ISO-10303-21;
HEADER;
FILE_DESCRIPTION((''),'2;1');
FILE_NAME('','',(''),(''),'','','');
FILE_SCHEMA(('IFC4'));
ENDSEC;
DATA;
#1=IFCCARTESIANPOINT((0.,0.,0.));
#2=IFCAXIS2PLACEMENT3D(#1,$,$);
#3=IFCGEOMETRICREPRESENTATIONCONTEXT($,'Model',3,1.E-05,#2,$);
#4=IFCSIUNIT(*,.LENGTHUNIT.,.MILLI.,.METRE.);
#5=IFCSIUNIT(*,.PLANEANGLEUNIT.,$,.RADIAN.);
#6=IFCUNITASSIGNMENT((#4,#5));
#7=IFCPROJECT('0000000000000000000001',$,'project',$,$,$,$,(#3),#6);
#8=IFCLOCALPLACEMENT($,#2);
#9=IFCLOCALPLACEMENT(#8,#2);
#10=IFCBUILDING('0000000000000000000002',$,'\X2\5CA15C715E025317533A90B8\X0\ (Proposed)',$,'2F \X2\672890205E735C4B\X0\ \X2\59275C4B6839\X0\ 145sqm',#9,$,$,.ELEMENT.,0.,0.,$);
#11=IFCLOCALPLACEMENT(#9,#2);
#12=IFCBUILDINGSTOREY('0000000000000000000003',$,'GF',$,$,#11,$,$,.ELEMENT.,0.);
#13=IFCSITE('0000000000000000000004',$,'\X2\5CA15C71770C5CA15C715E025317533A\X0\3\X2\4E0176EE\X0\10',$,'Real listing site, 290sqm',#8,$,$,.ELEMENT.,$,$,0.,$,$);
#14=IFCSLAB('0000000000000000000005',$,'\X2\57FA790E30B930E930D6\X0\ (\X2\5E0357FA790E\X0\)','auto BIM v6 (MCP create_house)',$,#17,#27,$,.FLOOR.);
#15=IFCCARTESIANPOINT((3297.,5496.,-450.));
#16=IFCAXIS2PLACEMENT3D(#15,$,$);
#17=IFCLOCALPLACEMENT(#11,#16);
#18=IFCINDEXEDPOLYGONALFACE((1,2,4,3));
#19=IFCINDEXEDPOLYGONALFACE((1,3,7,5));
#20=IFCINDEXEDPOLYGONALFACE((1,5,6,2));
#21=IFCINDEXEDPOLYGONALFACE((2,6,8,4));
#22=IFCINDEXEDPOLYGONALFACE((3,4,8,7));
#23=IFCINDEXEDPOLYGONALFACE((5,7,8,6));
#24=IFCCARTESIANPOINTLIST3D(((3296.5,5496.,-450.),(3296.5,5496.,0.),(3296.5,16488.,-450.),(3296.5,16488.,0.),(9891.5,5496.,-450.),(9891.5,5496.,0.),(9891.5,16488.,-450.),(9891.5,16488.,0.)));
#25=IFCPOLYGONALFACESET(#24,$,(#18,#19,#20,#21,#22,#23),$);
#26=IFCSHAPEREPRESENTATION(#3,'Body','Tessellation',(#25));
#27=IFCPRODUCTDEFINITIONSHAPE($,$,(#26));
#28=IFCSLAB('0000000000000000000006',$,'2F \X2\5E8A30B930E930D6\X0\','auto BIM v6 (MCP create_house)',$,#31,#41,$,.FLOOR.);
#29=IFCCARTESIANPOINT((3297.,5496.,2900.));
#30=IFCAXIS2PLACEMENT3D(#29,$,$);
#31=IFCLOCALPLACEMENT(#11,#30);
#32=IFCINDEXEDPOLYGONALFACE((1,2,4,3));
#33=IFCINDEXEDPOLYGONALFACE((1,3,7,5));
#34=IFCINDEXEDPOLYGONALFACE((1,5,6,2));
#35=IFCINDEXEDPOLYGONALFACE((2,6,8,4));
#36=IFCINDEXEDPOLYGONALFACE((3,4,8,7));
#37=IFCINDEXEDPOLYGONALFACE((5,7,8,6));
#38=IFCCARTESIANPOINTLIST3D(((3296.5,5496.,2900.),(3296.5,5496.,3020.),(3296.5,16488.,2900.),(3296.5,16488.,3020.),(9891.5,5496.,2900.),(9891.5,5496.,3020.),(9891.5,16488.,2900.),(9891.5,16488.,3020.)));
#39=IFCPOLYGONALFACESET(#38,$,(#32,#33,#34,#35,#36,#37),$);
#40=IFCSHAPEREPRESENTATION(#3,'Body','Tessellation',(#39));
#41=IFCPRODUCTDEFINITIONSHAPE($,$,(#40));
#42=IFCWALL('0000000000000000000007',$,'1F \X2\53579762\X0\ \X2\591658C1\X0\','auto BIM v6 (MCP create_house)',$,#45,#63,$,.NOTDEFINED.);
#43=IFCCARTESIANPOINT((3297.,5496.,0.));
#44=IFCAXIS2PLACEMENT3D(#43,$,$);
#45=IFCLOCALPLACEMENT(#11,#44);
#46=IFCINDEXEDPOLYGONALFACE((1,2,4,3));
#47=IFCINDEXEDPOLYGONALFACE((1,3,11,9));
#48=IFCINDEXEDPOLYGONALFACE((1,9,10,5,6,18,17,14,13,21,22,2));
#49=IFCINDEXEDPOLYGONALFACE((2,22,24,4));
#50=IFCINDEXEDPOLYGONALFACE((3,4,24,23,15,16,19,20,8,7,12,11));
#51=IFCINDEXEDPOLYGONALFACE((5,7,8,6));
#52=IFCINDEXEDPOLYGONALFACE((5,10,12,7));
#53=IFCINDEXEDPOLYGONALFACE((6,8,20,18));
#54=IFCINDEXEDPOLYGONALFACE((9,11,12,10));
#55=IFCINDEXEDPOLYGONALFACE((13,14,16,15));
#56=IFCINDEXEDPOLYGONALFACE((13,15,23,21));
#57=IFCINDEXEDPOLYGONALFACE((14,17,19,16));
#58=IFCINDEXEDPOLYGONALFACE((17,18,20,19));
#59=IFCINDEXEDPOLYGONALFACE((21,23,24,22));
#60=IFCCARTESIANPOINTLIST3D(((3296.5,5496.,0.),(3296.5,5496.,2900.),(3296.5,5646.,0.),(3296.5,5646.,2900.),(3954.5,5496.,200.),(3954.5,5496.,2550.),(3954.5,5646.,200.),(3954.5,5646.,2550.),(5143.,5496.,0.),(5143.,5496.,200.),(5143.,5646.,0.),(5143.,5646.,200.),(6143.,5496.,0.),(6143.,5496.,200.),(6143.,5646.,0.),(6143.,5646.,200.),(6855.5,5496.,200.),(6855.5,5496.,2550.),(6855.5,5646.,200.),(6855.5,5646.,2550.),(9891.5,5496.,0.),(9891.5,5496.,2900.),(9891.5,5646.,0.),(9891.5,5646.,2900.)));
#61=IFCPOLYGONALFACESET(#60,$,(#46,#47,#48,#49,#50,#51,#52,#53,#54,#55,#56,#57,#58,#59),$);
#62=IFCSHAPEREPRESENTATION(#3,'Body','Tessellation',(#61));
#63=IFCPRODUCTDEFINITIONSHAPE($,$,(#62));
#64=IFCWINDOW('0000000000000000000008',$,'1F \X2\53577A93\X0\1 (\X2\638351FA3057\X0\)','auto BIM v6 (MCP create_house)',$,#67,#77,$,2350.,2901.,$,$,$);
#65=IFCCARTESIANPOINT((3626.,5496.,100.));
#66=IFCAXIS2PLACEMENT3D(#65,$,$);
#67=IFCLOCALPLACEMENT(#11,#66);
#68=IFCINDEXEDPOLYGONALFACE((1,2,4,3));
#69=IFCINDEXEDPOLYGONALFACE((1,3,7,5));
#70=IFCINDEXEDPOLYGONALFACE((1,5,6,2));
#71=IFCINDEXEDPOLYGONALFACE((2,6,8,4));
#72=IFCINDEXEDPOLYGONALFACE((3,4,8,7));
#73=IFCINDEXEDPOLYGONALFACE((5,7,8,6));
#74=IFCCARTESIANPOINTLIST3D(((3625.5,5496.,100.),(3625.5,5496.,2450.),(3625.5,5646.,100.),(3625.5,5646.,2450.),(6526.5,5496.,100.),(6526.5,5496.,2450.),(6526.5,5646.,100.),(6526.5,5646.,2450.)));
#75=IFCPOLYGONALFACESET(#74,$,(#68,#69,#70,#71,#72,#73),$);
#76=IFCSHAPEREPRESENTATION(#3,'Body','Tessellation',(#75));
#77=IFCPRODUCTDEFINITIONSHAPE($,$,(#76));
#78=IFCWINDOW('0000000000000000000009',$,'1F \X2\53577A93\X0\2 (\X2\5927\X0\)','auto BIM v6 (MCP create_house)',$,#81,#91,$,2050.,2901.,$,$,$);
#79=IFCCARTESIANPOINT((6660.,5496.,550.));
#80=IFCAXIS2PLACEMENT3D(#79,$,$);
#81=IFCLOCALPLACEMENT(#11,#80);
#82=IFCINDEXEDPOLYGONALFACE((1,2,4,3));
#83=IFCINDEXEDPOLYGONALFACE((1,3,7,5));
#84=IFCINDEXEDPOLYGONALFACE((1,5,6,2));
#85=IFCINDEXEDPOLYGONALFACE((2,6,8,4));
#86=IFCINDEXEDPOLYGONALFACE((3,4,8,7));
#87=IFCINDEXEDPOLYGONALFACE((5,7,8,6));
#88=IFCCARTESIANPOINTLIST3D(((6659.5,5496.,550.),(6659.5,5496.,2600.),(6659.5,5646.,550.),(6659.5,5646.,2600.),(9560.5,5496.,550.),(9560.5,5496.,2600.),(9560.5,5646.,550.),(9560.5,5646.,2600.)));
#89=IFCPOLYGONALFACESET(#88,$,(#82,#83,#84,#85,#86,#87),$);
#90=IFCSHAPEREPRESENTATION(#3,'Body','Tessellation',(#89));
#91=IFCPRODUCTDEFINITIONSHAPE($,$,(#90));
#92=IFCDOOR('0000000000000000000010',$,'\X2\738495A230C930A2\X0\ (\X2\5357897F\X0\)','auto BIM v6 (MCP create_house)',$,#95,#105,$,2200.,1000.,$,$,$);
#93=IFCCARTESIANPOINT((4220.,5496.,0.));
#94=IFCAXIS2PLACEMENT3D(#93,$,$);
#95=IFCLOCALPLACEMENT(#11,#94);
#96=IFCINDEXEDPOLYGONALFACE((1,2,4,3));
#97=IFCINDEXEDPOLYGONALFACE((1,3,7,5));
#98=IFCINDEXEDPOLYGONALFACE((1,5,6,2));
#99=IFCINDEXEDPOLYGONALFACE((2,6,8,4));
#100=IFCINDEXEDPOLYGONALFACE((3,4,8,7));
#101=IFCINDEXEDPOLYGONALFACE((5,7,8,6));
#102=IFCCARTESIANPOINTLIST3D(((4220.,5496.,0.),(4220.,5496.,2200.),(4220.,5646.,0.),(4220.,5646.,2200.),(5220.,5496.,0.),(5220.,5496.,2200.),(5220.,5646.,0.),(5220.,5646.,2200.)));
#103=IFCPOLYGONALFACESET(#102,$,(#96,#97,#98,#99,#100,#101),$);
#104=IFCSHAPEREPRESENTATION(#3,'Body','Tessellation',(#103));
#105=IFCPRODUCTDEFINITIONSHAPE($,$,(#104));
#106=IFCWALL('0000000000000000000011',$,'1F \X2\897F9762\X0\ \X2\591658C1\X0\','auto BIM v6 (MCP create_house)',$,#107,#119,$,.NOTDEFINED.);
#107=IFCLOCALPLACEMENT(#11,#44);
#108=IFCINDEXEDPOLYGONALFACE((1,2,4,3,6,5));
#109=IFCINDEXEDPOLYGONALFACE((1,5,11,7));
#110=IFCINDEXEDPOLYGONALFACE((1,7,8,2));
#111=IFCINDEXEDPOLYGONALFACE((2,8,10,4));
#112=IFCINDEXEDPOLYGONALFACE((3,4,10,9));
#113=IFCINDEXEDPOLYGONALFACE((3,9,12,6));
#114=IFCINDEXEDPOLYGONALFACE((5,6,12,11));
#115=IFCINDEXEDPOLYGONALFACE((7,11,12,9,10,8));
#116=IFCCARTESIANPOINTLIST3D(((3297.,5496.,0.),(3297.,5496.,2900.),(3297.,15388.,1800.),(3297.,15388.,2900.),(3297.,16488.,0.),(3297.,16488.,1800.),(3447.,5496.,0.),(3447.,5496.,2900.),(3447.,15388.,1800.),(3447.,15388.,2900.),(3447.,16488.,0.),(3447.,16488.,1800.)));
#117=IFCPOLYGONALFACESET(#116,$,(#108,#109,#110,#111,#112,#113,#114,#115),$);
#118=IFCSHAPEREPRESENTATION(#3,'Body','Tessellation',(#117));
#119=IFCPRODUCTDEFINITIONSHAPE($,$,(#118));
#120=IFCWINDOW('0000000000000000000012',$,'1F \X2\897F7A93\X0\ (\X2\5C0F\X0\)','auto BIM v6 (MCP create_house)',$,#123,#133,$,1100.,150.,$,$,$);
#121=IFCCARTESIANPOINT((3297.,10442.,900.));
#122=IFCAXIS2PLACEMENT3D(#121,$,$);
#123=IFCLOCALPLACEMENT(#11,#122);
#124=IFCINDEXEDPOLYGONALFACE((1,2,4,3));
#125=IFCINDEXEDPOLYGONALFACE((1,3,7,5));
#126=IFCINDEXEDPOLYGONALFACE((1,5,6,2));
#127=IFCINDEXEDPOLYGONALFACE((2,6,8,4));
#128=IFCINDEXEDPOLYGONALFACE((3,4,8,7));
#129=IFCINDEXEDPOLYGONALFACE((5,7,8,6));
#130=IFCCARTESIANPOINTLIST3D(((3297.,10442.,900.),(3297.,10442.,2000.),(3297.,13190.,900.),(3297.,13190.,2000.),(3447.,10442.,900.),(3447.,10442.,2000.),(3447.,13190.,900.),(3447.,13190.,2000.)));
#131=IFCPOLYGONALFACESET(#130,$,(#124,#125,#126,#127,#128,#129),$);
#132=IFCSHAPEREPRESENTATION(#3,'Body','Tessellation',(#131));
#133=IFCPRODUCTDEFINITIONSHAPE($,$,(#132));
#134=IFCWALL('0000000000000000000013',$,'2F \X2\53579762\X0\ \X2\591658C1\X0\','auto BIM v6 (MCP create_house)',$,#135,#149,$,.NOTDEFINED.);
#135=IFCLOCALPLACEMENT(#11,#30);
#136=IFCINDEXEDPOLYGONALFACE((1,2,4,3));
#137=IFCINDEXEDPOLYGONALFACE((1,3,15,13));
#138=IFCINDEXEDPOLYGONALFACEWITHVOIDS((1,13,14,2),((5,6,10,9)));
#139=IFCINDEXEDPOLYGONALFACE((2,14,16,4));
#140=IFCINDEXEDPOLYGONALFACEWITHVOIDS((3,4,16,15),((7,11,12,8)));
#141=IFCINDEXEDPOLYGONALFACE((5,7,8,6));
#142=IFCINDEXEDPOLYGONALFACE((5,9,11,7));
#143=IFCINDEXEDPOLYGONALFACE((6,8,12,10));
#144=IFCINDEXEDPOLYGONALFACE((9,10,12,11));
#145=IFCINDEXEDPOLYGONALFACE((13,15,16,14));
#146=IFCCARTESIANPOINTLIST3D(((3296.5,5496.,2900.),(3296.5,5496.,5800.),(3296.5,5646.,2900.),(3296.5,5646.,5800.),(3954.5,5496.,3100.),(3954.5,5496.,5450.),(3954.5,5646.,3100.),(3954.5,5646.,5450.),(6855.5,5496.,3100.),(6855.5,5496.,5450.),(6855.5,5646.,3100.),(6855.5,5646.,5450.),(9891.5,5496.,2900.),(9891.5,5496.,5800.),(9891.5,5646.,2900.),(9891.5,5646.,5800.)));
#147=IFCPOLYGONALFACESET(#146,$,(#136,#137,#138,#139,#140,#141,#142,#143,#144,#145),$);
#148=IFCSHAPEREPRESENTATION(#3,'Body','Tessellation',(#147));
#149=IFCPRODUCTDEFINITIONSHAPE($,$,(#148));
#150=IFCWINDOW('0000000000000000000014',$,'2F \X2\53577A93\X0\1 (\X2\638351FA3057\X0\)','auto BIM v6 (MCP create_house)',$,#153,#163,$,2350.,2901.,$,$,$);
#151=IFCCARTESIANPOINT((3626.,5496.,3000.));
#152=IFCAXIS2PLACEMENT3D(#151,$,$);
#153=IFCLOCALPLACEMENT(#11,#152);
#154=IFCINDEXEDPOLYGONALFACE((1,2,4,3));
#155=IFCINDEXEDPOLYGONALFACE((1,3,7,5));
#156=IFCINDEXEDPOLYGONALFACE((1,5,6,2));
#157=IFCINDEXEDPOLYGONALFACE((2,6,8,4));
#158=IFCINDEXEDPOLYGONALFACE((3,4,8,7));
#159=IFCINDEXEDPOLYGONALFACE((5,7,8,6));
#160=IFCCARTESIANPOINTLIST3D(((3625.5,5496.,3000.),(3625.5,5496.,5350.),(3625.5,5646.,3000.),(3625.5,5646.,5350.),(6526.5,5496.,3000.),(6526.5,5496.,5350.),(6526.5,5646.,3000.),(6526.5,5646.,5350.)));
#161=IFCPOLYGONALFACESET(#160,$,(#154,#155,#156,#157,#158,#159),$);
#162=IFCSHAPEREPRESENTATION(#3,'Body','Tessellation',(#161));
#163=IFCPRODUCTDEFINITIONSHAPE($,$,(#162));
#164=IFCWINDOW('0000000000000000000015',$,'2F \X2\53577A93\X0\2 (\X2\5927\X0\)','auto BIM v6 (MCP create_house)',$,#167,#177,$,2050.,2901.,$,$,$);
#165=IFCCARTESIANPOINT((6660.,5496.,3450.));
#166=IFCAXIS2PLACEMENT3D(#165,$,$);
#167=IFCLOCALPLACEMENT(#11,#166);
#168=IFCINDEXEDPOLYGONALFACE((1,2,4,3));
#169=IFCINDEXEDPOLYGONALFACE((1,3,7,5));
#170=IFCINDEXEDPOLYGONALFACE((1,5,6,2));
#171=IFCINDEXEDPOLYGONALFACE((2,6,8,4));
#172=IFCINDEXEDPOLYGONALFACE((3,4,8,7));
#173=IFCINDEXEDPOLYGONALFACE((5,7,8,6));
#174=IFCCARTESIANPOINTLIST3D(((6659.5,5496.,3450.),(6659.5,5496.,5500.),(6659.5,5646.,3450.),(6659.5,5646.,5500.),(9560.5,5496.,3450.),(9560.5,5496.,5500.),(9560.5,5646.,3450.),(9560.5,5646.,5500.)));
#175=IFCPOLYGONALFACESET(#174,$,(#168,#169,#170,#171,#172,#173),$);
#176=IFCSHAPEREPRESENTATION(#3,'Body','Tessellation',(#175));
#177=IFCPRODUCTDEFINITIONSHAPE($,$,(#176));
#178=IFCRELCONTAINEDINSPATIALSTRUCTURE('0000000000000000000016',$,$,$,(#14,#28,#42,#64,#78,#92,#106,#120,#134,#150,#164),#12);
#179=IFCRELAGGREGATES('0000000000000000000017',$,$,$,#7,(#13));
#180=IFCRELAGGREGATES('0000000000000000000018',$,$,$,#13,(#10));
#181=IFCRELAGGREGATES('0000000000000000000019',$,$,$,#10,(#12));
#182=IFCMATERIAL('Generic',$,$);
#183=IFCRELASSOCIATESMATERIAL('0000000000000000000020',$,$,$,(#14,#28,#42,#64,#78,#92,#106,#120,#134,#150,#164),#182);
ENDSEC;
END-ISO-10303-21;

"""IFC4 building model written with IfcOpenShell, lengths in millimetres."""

from ifc_helpers import new_model, si_unit, frame, frame_2d, origin, place, context, project, spatial, rectangle, extrude, material, element, fill, save


model = new_model("IFC4")

# Units and contexts
model_context = context("Model", 3, precision=1e-05, world=origin())
ifc_project = project(units=[si_unit("LENGTHUNIT", "METRE", prefix="MILLI"), si_unit("PLANEANGLEUNIT", "RADIAN")], contexts=[model_context])

# Site, building, storey
site_placement = place(None, origin())
site = spatial("IfcSite", under=ifc_project, at=site_placement, Name="岡山県岡山市北区3丁目10", ObjectType="Real listing site, 290sqm", CompositionType="ELEMENT", RefElevation=0.0)
building_placement = place(site_placement, origin())
building = spatial("IfcBuilding", under=site, at=building_placement, Name="岡山市北区邸 (Proposed)", ObjectType="2F 木造平屋 大屋根 145sqm", CompositionType="ELEMENT", ElevationOfRefHeight=0.0, ElevationOfTerrain=0.0)
storey_placement = place(building_placement, origin())
storey = spatial("IfcBuildingStorey", under=building, at=storey_placement, Name="GF", CompositionType="ELEMENT", Elevation=0.0)

# Slabs
ifc_material = material(Name="Generic")
slab_1_placement = place(storey_placement, frame((3297.0, 5496.0, -450.0)))
element("IfcSlab", 1, at=slab_1_placement, inside=storey, material=ifc_material, Name="基礎スラブ (布基礎)", Description="auto BIM v6 (MCP create_house)", PredefinedType="FLOOR", context=model_context, shape_type="SweptSolid", body=[
    extrude(rectangle(XDim=6595.0, YDim=10992.0, at=frame_2d((3297.0, 5496.0))), frame((3297.0, 5496.0, -450.0)), (0.0, 0.0, 1.0), 450.0),
])
slab_2_placement = place(storey_placement, frame((3297.0, 5496.0, 2900.0)))
element("IfcSlab", 2, at=slab_2_placement, inside=storey, material=ifc_material, Name="2F 床スラブ", Description="auto BIM v6 (MCP create_house)", PredefinedType="FLOOR", context=model_context, shape_type="SweptSolid", body=[
    extrude(rectangle(XDim=6595.0, YDim=10992.0, at=frame_2d((3297.0, 5496.0))), frame((3297.0, 5496.0, 2900.0)), (0.0, 0.0, 1.0), 120.0),
])

# Wall, openings, windows, door
wall_1_placement = place(storey_placement, frame((3297.0, 5496.0, 0.0)))
wall_1 = element("IfcWall", 3, at=wall_1_placement, inside=storey, material=ifc_material, Name="1F 南面 外壁", Description="auto BIM v6 (MCP create_house)", PredefinedType="NOTDEFINED", context=model_context, shape_type="SweptSolid", body=[
    extrude(rectangle(XDim=6595.0, YDim=150.0, at=frame_2d((3297.0, 75.0))), frame((3297.0, 5496.0, 0.0)), (0.0, 0.0, 1.0), 2900.0),
])
opening_1_placement = place(storey_placement, frame((3626.0, 5496.0, 100.0)))
opening_1 = element("IfcOpeningElement", 4, at=opening_1_placement, cuts=wall_1, PredefinedType="NOTDEFINED", context=model_context, shape_type="SweptSolid", body=[
    extrude(rectangle(XDim=2901.0, YDim=150.0, at=frame_2d((1450.0, 75.0))), frame((3626.0, 5496.0, 100.0)), (0.0, 0.0, 1.0), 2350.0),
])
opening_2_placement = place(storey_placement, frame((6660.0, 5496.0, 550.0)))
opening_2 = element("IfcOpeningElement", 5, at=opening_2_placement, cuts=wall_1, PredefinedType="NOTDEFINED", context=model_context, shape_type="SweptSolid", body=[
    extrude(rectangle(XDim=2901.0, YDim=150.0, at=frame_2d((1450.0, 75.0))), frame((6660.0, 5496.0, 550.0)), (0.0, 0.0, 1.0), 2050.0),
])
opening_3_placement = place(storey_placement, frame((4220.0, 5496.0, 0.0)))
opening_3 = element("IfcOpeningElement", 6, at=opening_3_placement, cuts=wall_1, PredefinedType="NOTDEFINED", context=model_context, shape_type="SweptSolid", body=[
    extrude(rectangle(XDim=1000.0, YDim=150.0, at=frame_2d((500.0, 75.0))), frame((4220.0, 5496.0, 0.0)), (0.0, 0.0, 1.0), 2200.0),
])
window_1_placement = place(storey_placement, frame((3626.0, 5496.0, 100.0)))
window_1 = element("IfcWindow", 7, at=window_1_placement, inside=storey, material=ifc_material, Name="1F 南窓1 (掃出し)", Description="auto BIM v6 (MCP create_house)", OverallHeight=2350.0, OverallWidth=2901.0, context=model_context, shape_type="SweptSolid", body=[
    extrude(rectangle(XDim=2901.0, YDim=150.0, at=frame_2d((1450.0, 75.0))), frame((3626.0, 5496.0, 100.0)), (0.0, 0.0, 1.0), 2350.0),
])
fill(opening_1, window_1)
window_2_placement = place(storey_placement, frame((6660.0, 5496.0, 550.0)))
window_2 = element("IfcWindow", 8, at=window_2_placement, inside=storey, material=ifc_material, Name="1F 南窓2 (大)", Description="auto BIM v6 (MCP create_house)", OverallHeight=2050.0, OverallWidth=2901.0, context=model_context, shape_type="SweptSolid", body=[
    extrude(rectangle(XDim=2901.0, YDim=150.0, at=frame_2d((1450.0, 75.0))), frame((6660.0, 5496.0, 550.0)), (0.0, 0.0, 1.0), 2050.0),
])
fill(opening_2, window_2)
door_placement = place(storey_placement, frame((4220.0, 5496.0, 0.0)))
door = element("IfcDoor", 9, at=door_placement, inside=storey, material=ifc_material, Name="玄関ドア (南西)", Description="auto BIM v6 (MCP create_house)", OverallHeight=2200.0, OverallWidth=1000.0, context=model_context, shape_type="SweptSolid", body=[
    extrude(rectangle(XDim=1000.0, YDim=150.0, at=frame_2d((500.0, 75.0))), frame((4220.0, 5496.0, 0.0)), (0.0, 0.0, 1.0), 2200.0),
])
fill(opening_3, door)

# Wall, opening, window
wall_2_placement = place(storey_placement, frame((3297.0, 5496.0, 0.0)))
wall_2 = element("IfcWall", 10, at=wall_2_placement, inside=storey, material=ifc_material, Name="1F 西面 外壁", Description="auto BIM v6 (MCP create_house)", PredefinedType="NOTDEFINED", context=model_context, shape_type="SweptSolid", body=[
    extrude(rectangle(XDim=150.0, YDim=10992.0, at=frame_2d((75.0, 5496.0))), frame((3297.0, 5496.0, 0.0)), (0.0, 0.0, 1.0), 2900.0),
])
opening_4_placement = place(storey_placement, frame((3297.0, 10442.0, 900.0)))
opening_4 = element("IfcOpeningElement", 11, at=opening_4_placement, cuts=wall_2, PredefinedType="NOTDEFINED", context=model_context, shape_type="SweptSolid", body=[
    extrude(rectangle(XDim=150.0, YDim=2748.0, at=frame_2d((75.0, 1374.0))), frame((3297.0, 10442.0, 900.0)), (0.0, 0.0, 1.0), 1100.0),
])
window_3_placement = place(storey_placement, frame((3297.0, 10442.0, 900.0)))
window_3 = element("IfcWindow", 12, at=window_3_placement, inside=storey, material=ifc_material, Name="1F 西窓 (小)", Description="auto BIM v6 (MCP create_house)", OverallHeight=1100.0, OverallWidth=150.0, context=model_context, shape_type="SweptSolid", body=[
    extrude(rectangle(XDim=150.0, YDim=2748.0, at=frame_2d((75.0, 1374.0))), frame((3297.0, 10442.0, 900.0)), (0.0, 0.0, 1.0), 1100.0),
])
fill(opening_4, window_3)

# Wall, openings, windows
wall_3_placement = place(storey_placement, frame((3297.0, 5496.0, 2900.0)))
wall_3 = element("IfcWall", 13, at=wall_3_placement, inside=storey, material=ifc_material, Name="2F 南面 外壁", Description="auto BIM v6 (MCP create_house)", PredefinedType="NOTDEFINED", context=model_context, shape_type="SweptSolid", body=[
    extrude(rectangle(XDim=6595.0, YDim=150.0, at=frame_2d((3297.0, 75.0))), frame((3297.0, 5496.0, 2900.0)), (0.0, 0.0, 1.0), 2900.0),
])
opening_5_placement = place(storey_placement, frame((3626.0, 5496.0, 3000.0)))
opening_5 = element("IfcOpeningElement", 14, at=opening_5_placement, cuts=wall_3, PredefinedType="NOTDEFINED", context=model_context, shape_type="SweptSolid", body=[
    extrude(rectangle(XDim=2901.0, YDim=150.0, at=frame_2d((1450.0, 75.0))), frame((3626.0, 5496.0, 3000.0)), (0.0, 0.0, 1.0), 2350.0),
])
opening_6_placement = place(storey_placement, frame((6660.0, 5496.0, 3450.0)))
opening_6 = element("IfcOpeningElement", 15, at=opening_6_placement, cuts=wall_3, PredefinedType="NOTDEFINED", context=model_context, shape_type="SweptSolid", body=[
    extrude(rectangle(XDim=2901.0, YDim=150.0, at=frame_2d((1450.0, 75.0))), frame((6660.0, 5496.0, 3450.0)), (0.0, 0.0, 1.0), 2050.0),
])
window_4_placement = place(storey_placement, frame((3626.0, 5496.0, 3000.0)))
window_4 = element("IfcWindow", 16, at=window_4_placement, inside=storey, material=ifc_material, Name="2F 南窓1 (掃出し)", Description="auto BIM v6 (MCP create_house)", OverallHeight=2350.0, OverallWidth=2901.0, context=model_context, shape_type="SweptSolid", body=[
    extrude(rectangle(XDim=2901.0, YDim=150.0, at=frame_2d((1450.0, 75.0))), frame((3626.0, 5496.0, 3000.0)), (0.0, 0.0, 1.0), 2350.0),
])
fill(opening_5, window_4)
window_5_placement = place(storey_placement, frame((6660.0, 5496.0, 3450.0)))
window_5 = element("IfcWindow", 17, at=window_5_placement, inside=storey, material=ifc_material, Name="2F 南窓2 (大)", Description="auto BIM v6 (MCP create_house)", OverallHeight=2050.0, OverallWidth=2901.0, context=model_context, shape_type="SweptSolid", body=[
    extrude(rectangle(XDim=2901.0, YDim=150.0, at=frame_2d((1450.0, 75.0))), frame((6660.0, 5496.0, 3450.0)), (0.0, 0.0, 1.0), 2050.0),
])
fill(opening_6, window_5)

save(model, "model.ifc")
